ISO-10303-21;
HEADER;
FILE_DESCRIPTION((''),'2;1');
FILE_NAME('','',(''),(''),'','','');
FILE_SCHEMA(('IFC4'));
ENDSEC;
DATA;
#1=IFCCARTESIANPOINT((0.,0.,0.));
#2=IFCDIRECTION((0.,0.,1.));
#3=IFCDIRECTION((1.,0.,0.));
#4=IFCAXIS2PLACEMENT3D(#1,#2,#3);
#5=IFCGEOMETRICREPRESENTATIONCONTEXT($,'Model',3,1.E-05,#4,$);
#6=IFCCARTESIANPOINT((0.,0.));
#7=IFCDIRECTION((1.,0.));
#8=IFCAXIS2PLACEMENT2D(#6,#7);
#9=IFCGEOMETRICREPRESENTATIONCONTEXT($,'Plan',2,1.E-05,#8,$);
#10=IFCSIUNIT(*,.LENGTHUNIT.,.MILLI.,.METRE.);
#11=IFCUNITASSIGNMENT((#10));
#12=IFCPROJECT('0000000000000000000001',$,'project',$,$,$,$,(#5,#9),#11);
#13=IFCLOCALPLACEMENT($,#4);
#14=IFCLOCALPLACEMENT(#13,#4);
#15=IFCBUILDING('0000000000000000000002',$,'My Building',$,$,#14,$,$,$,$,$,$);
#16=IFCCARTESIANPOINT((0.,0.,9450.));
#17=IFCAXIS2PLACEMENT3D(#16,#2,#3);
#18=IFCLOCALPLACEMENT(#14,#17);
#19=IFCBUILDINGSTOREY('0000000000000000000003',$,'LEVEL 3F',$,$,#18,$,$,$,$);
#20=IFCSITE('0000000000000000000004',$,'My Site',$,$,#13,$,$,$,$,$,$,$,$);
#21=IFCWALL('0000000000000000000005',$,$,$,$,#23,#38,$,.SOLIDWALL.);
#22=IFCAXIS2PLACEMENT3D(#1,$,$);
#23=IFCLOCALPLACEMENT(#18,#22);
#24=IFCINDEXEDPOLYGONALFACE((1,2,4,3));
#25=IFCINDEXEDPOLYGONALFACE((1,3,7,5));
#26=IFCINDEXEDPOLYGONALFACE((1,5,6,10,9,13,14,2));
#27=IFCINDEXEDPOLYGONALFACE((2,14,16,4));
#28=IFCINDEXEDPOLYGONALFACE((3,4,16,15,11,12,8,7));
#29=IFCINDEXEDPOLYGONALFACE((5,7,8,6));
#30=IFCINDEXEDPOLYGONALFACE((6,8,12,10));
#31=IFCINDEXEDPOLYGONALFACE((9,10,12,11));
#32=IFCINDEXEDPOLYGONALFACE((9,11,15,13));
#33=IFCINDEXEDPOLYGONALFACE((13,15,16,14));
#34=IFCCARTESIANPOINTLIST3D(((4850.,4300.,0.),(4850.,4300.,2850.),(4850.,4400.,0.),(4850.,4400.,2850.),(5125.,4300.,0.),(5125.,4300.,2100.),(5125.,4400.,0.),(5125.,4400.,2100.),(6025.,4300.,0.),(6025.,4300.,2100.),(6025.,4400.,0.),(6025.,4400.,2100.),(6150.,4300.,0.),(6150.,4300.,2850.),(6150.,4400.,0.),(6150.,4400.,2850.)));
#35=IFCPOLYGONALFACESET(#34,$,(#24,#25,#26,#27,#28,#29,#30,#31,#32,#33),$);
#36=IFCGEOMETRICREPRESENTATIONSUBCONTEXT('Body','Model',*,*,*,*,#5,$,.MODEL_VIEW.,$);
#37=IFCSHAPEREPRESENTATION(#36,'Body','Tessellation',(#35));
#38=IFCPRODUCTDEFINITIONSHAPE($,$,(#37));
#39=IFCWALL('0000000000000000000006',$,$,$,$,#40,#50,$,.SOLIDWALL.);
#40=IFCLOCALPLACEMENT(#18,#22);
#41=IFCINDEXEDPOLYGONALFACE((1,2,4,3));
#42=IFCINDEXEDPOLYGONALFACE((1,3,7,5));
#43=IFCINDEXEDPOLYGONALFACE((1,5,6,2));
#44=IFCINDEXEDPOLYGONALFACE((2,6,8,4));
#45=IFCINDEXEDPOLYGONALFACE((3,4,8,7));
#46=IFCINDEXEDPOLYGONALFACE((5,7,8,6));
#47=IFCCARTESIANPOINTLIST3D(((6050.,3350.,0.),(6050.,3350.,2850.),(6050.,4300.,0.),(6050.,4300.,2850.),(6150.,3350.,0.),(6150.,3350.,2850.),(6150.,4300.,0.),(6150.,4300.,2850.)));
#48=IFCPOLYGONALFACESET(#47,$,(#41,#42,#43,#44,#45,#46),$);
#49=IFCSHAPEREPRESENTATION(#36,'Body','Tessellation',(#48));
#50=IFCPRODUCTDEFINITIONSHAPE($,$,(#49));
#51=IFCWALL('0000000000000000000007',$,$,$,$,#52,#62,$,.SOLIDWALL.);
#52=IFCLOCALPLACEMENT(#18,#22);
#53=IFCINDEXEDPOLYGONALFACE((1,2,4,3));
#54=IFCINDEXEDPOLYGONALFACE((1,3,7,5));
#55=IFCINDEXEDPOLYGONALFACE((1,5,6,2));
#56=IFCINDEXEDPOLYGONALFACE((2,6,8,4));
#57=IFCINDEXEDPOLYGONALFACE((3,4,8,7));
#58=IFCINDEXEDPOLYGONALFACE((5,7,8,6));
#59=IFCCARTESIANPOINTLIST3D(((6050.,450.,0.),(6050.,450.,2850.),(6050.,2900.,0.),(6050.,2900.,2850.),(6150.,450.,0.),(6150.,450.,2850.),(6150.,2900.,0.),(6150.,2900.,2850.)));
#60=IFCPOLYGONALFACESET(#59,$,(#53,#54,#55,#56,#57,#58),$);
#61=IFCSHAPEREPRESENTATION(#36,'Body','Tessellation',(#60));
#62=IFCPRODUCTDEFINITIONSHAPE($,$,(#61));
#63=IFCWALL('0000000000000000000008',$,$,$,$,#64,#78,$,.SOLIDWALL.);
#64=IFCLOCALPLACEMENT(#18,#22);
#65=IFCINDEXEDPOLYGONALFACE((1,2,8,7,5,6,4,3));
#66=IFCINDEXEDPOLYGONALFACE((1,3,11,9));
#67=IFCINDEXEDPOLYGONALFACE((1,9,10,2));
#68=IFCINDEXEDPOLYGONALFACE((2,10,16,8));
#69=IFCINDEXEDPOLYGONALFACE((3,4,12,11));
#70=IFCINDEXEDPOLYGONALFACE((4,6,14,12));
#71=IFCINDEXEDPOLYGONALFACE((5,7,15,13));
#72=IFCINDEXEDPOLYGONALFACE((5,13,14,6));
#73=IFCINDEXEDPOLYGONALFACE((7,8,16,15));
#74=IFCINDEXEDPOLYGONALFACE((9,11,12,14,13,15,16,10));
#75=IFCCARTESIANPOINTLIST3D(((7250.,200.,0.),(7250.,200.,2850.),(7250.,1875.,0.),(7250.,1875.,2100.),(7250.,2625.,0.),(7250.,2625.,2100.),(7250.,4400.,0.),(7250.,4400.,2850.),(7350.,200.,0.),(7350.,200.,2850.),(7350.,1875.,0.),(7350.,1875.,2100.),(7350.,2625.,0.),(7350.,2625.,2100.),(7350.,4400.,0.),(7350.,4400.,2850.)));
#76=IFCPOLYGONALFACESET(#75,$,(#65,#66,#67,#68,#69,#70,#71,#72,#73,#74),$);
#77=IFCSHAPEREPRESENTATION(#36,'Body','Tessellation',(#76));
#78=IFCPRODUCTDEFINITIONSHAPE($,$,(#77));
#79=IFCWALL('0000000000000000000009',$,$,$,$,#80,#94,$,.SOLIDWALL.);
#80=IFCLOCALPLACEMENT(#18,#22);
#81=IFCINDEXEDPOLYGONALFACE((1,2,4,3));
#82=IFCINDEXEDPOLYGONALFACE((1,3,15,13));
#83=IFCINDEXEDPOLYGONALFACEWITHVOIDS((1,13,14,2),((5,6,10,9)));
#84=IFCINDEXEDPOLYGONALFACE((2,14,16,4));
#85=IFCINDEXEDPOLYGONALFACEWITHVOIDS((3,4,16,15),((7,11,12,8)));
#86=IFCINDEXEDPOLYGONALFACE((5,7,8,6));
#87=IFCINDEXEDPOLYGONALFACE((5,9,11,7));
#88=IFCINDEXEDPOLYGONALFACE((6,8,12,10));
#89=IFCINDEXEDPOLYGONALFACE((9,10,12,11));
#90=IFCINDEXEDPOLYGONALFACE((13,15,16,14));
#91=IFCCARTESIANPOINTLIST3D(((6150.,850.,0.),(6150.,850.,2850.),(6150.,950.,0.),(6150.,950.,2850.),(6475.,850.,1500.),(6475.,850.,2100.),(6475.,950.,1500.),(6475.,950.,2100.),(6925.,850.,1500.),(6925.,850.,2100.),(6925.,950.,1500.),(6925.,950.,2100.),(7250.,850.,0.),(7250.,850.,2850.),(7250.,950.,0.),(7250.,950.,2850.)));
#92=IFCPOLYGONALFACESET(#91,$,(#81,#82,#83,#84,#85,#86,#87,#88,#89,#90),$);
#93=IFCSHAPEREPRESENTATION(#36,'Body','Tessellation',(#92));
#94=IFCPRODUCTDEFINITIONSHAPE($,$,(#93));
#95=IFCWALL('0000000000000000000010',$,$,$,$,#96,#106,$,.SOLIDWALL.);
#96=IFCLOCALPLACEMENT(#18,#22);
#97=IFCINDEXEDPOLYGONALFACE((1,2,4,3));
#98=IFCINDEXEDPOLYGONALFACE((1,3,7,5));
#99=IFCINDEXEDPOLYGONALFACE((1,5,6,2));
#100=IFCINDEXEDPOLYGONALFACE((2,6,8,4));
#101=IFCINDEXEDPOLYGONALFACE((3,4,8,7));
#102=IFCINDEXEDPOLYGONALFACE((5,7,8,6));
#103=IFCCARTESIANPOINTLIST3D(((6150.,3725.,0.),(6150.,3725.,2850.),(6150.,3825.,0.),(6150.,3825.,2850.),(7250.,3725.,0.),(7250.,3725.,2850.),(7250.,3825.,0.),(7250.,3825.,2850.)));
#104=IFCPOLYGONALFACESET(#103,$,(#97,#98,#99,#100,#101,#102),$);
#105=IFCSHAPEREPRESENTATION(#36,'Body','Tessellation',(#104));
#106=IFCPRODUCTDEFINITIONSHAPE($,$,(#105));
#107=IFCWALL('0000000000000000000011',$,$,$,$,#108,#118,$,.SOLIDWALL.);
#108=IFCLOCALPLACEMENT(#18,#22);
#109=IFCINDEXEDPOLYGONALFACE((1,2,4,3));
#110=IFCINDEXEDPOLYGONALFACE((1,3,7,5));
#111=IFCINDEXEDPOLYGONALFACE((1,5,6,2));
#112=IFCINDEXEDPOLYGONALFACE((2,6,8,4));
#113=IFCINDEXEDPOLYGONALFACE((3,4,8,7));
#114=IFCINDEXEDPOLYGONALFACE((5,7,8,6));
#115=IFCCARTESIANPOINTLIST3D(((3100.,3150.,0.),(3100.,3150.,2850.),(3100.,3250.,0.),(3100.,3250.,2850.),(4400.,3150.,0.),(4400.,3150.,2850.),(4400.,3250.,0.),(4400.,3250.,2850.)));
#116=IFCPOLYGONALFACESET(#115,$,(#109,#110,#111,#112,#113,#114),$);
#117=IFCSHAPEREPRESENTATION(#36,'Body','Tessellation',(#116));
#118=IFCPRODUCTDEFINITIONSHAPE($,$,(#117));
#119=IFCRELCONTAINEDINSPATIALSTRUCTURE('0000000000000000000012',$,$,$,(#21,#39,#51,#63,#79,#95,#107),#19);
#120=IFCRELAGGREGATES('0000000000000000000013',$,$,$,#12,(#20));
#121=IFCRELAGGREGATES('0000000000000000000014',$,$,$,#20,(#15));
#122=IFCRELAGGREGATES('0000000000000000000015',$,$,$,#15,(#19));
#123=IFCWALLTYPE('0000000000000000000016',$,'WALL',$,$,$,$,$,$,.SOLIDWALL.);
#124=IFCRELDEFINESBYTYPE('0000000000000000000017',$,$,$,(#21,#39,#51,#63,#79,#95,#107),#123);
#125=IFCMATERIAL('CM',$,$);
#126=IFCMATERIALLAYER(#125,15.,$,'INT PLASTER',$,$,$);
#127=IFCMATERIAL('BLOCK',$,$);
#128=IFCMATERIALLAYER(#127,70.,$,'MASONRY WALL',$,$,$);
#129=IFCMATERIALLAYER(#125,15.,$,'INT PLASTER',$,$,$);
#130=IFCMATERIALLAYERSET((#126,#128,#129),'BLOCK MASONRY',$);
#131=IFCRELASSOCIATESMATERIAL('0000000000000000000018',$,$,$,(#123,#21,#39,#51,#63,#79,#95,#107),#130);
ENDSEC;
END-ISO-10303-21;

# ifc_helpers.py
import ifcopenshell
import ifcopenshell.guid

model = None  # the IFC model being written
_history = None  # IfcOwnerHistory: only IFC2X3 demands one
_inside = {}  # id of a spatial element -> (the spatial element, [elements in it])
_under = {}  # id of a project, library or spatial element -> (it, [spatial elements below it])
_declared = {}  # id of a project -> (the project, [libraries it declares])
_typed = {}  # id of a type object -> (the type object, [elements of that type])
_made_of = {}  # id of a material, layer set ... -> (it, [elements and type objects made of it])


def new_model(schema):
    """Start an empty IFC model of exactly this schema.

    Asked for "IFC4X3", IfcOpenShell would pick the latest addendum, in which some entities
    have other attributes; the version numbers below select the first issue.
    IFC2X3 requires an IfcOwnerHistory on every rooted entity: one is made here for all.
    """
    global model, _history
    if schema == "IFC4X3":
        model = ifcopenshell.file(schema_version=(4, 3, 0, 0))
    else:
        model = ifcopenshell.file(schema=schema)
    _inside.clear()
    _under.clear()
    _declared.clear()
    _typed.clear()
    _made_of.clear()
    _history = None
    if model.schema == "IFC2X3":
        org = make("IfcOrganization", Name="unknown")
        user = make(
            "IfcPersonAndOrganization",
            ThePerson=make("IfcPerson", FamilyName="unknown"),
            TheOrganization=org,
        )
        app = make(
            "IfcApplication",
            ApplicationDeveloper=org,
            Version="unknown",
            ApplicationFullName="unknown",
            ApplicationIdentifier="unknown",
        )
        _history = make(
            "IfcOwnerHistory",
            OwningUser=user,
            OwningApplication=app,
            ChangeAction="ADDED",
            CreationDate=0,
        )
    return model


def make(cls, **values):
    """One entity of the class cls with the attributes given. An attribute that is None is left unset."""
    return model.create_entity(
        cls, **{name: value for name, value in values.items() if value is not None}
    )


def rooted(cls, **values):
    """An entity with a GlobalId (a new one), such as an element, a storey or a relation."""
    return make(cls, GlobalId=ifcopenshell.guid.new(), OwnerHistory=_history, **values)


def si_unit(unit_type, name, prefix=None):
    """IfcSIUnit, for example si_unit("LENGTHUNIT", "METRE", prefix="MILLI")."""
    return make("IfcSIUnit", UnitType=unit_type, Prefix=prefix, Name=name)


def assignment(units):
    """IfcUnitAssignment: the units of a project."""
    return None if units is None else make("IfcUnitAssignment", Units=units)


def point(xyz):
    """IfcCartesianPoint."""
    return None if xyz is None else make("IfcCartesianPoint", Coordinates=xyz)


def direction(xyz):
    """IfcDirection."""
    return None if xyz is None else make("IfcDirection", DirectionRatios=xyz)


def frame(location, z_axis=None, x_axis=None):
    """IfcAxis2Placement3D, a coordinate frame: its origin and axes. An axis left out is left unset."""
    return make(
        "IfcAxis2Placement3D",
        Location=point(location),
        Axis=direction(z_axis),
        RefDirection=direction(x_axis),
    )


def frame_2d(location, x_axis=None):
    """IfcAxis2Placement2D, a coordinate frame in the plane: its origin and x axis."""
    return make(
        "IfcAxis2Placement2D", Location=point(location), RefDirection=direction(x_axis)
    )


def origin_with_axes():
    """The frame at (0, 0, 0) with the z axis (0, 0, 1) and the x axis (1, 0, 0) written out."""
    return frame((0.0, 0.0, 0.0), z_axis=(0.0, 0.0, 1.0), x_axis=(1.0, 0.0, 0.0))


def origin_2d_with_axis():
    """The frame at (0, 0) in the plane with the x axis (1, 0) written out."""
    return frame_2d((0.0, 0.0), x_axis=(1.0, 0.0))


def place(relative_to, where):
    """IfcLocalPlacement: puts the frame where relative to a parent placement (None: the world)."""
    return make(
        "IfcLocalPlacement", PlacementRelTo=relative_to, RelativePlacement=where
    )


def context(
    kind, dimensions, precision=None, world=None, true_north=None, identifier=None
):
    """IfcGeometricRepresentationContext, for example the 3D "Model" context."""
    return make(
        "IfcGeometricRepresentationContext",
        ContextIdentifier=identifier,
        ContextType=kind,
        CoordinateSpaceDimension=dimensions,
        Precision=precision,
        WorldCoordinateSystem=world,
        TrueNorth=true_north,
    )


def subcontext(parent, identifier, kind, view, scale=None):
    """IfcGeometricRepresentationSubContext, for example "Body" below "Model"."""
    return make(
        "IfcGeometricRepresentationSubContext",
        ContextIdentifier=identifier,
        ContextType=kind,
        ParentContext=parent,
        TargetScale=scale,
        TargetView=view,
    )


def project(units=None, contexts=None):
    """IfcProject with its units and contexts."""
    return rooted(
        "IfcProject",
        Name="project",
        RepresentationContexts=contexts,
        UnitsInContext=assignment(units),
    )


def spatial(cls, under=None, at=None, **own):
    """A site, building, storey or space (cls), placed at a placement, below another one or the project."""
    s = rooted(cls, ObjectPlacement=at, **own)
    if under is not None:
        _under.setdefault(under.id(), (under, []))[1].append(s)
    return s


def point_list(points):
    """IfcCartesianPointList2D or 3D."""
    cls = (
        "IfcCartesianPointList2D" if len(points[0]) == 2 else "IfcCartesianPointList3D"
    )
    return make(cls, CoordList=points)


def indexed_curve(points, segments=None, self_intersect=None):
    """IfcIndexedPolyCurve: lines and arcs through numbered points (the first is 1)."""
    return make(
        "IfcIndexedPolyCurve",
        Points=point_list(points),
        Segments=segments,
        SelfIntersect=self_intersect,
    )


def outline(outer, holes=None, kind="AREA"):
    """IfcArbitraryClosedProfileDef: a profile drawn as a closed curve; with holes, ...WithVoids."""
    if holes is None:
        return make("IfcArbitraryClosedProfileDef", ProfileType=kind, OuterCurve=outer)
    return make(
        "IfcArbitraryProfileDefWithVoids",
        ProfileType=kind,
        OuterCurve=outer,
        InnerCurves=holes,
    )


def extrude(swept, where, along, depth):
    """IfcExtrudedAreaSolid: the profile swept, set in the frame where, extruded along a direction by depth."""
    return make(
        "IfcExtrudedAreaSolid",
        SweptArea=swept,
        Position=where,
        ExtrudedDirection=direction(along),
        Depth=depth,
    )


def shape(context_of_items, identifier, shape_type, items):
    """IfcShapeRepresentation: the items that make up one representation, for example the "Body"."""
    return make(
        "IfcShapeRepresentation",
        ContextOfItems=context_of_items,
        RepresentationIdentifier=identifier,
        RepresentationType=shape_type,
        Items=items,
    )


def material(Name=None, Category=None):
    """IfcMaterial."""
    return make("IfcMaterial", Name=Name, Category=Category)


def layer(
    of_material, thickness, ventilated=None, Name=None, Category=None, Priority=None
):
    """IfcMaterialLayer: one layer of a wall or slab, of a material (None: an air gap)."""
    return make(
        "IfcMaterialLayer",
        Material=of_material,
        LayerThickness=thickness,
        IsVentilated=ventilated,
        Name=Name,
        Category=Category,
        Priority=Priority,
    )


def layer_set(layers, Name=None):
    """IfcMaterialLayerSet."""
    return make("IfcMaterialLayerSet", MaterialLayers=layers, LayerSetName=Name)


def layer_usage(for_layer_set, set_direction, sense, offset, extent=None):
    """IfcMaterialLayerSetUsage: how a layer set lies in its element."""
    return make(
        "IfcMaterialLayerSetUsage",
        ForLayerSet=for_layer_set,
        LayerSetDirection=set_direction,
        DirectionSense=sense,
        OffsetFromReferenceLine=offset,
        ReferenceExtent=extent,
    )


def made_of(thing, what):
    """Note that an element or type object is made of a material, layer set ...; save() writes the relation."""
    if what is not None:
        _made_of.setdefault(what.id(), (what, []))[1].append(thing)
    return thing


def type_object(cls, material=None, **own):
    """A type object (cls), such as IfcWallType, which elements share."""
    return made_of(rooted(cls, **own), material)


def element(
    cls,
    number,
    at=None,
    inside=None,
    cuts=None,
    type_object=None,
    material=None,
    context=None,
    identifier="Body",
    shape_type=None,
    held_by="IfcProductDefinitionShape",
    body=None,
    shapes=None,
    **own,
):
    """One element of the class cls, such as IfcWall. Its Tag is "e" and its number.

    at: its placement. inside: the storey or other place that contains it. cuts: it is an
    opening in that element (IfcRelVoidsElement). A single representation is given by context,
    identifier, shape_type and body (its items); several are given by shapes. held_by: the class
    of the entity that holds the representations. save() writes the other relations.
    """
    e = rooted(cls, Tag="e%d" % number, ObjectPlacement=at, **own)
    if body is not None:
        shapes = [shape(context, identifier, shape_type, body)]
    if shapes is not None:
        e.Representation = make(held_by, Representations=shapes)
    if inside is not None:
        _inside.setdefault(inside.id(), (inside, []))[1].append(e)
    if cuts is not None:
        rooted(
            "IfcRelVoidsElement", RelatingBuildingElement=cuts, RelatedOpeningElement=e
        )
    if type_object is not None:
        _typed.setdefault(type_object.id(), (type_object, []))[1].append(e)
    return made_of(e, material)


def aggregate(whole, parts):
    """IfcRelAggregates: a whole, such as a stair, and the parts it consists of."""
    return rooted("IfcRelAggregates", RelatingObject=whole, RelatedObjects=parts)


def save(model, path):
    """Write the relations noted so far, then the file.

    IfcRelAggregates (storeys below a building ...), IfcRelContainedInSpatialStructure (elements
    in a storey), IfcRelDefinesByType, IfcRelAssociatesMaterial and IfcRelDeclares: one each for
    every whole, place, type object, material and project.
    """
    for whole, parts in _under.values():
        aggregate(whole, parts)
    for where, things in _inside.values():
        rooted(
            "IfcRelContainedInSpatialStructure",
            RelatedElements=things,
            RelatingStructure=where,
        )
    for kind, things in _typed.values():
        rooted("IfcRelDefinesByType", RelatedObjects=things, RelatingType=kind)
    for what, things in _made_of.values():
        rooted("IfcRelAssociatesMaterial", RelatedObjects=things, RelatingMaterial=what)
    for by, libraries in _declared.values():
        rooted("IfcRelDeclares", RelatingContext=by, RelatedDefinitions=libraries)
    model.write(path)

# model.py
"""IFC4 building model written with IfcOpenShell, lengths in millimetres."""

from ifc_helpers import new_model, si_unit, frame, origin_with_axes, origin_2d_with_axis, place, context, subcontext, project, spatial, indexed_curve, outline, extrude, material, layer, layer_set, layer_usage, type_object, element, save


model = new_model("IFC4")

# Units and contexts
model_context = context("Model", 3, precision=1e-05, world=origin_with_axes())
plan_context = context("Plan", 2, precision=1e-05, world=origin_2d_with_axis())
body_context = subcontext(model_context, "Body", "Model", "MODEL_VIEW")
ifc_project = project(units=[si_unit("LENGTHUNIT", "METRE", prefix="MILLI")], contexts=[model_context, plan_context])

# Site, building, storey
site_placement = place(None, origin_with_axes())
site = spatial("IfcSite", under=ifc_project, at=site_placement, Name="My Site")
building_placement = place(site_placement, origin_with_axes())
building = spatial("IfcBuilding", under=site, at=building_placement, Name="My Building")
storey_placement = place(building_placement, frame((0.0, 0.0, 9450.0), z_axis=(0.0, 0.0, 1.0), x_axis=(1.0, 0.0, 0.0)))
storey = spatial("IfcBuildingStorey", under=building, at=storey_placement, Name="LEVEL 3F")

# Shared definitions
ifc_material_1 = material(Name="CM")
ifc_layer_1 = layer(ifc_material_1, 15.0, Name="INT PLASTER")
ifc_material_2 = material(Name="BLOCK")
ifc_layer_2 = layer(ifc_material_2, 70.0, Name="MASONRY WALL")
ifc_layer_3 = layer(ifc_material_1, 15.0, Name="INT PLASTER")
ifc_layer_set_1 = layer_set([ifc_layer_1, ifc_layer_2, ifc_layer_3], Name="BLOCK MASONRY")
wall_type = type_object("IfcWallType", Name="WALL", PredefinedType="SOLIDWALL", material=ifc_layer_set_1)

# Wall, opening
ifc_layer_usage_1 = layer_usage(ifc_layer_set_1, "AXIS2", "POSITIVE", 0.0)
wall_1_placement = place(storey_placement, frame((4850.0, 4400.0, 0.0), z_axis=(0.0, 0.0, 1.0), x_axis=(0.0, -1.0, 0.0)))
wall_1 = element("IfcWall", 1, at=wall_1_placement, inside=storey, type_object=wall_type, material=ifc_layer_usage_1, PredefinedType="SOLIDWALL", context=body_context, shape_type="SweptSolid", body=[
    extrude(outline(indexed_curve([(0.0, 0.0), (0.0, 1300.0), (100.0, 1300.0), (100.0, 0.0), (0.0, 0.0)], self_intersect=False)), origin_with_axes(), (0.0, 0.0, 1.0), 2850.0),
])
opening_1_placement = place(wall_1_placement, frame((0.0, 1175.0, 0.0), z_axis=(0.0, 0.0, 1.0), x_axis=(0.0, -1.0, 0.0)))
element("IfcOpeningElement", 2, at=opening_1_placement, cuts=wall_1, PredefinedType="OPENING", context=body_context, shape_type="SweptSolid", body=[
    extrude(outline(indexed_curve([(0.0, 0.0), (0.0, 400.0), (900.0, 400.0), (900.0, 0.0), (0.0, 0.0)], self_intersect=False)), frame((0.0, -100.0, 0.0), z_axis=(0.0, 0.0, 1.0), x_axis=(1.0, 0.0, 0.0)), (0.0, 0.0, 1.0), 2100.0),
])

# Walls
ifc_layer_usage_2 = layer_usage(ifc_layer_set_1, "AXIS2", "POSITIVE", 0.0)
wall_2_placement = place(storey_placement, frame((6150.0, 3350.0, 0.0), z_axis=(0.0, 0.0, 1.0), x_axis=(0.0, 1.0, 0.0)))
element("IfcWall", 3, at=wall_2_placement, inside=storey, type_object=wall_type, material=ifc_layer_usage_2, PredefinedType="SOLIDWALL", context=body_context, shape_type="SweptSolid", body=[
    extrude(outline(indexed_curve([(0.0, 0.0), (0.0, 100.0), (950.0, 100.0), (950.0, 0.0), (0.0, 0.0)], self_intersect=False)), origin_with_axes(), (0.0, 0.0, 1.0), 2850.0),
])
ifc_layer_usage_3 = layer_usage(ifc_layer_set_1, "AXIS2", "POSITIVE", 0.0)
wall_3_placement = place(storey_placement, frame((6150.0, 450.0, 0.0), z_axis=(0.0, 0.0, 1.0), x_axis=(0.0, 1.0, 0.0)))
element("IfcWall", 4, at=wall_3_placement, inside=storey, type_object=wall_type, material=ifc_layer_usage_3, PredefinedType="SOLIDWALL", context=body_context, shape_type="SweptSolid", body=[
    extrude(outline(indexed_curve([(0.0, 0.0), (0.0, 100.0), (2450.0, 100.0), (2450.0, 0.0), (0.0, 0.0)], self_intersect=False)), origin_with_axes(), (0.0, 0.0, 1.0), 2850.0),
])

# Walls, openings
ifc_layer_usage_4 = layer_usage(ifc_layer_set_1, "AXIS2", "POSITIVE", 0.0)
wall_4_placement = place(storey_placement, frame((7350.0, 200.0, 0.0), z_axis=(0.0, 0.0, 1.0), x_axis=(0.0, 1.0, 0.0)))
wall_4 = element("IfcWall", 5, at=wall_4_placement, inside=storey, type_object=wall_type, material=ifc_layer_usage_4, PredefinedType="SOLIDWALL", context=body_context, shape_type="SweptSolid", body=[
    extrude(outline(indexed_curve([(0.0, 0.0), (0.0, 100.0), (4200.0, 100.0), (4200.0, 0.0), (0.0, 0.0)], self_intersect=False)), origin_with_axes(), (0.0, 0.0, 1.0), 2850.0),
])
opening_2_placement = place(wall_4_placement, frame((1675.0, 0.0, 0.0), z_axis=(0.0, 0.0, 1.0), x_axis=(1.0, 0.0, 0.0)))
element("IfcOpeningElement", 6, at=opening_2_placement, cuts=wall_4, PredefinedType="OPENING", context=body_context, shape_type="SweptSolid", body=[
    extrude(outline(indexed_curve([(0.0, 0.0), (0.0, 400.0), (750.0, 400.0), (750.0, 0.0), (0.0, 0.0)], self_intersect=False)), frame((0.0, -100.0, 0.0), z_axis=(0.0, 0.0, 1.0), x_axis=(1.0, 0.0, 0.0)), (0.0, 0.0, 1.0), 2100.0),
])
ifc_layer_usage_5 = layer_usage(ifc_layer_set_1, "AXIS2", "POSITIVE", 0.0)
wall_5_placement = place(storey_placement, frame((6150.0, 950.0, 0.0), z_axis=(0.0, 0.0, 1.0), x_axis=(0.0, -1.0, 0.0)))
wall_5 = element("IfcWall", 7, at=wall_5_placement, inside=storey, type_object=wall_type, material=ifc_layer_usage_5, PredefinedType="SOLIDWALL", context=body_context, shape_type="SweptSolid", body=[
    extrude(outline(indexed_curve([(0.0, 0.0), (0.0, 1100.0), (100.0, 1100.0), (100.0, 0.0), (0.0, 0.0)], self_intersect=False)), origin_with_axes(), (0.0, 0.0, 1.0), 2850.0),
])
opening_3_placement = place(wall_5_placement, frame((0.0, 775.0, 1500.0), z_axis=(0.0, 0.0, 1.0), x_axis=(0.0, -1.0, 0.0)))
element("IfcOpeningElement", 8, at=opening_3_placement, cuts=wall_5, PredefinedType="OPENING", context=body_context, shape_type="SweptSolid", body=[
    extrude(outline(indexed_curve([(0.0, 0.0), (0.0, 400.0), (450.0, 400.0), (450.0, 0.0), (0.0, 0.0)], self_intersect=False)), frame((0.0, -100.0, 0.0), z_axis=(0.0, 0.0, 1.0), x_axis=(1.0, 0.0, 0.0)), (0.0, 0.0, 1.0), 600.0),
])

# Walls
ifc_layer_usage_6 = layer_usage(ifc_layer_set_1, "AXIS2", "POSITIVE", 0.0)
wall_6_placement = place(storey_placement, frame((6150.0, 3825.0, 0.0), z_axis=(0.0, 0.0, 1.0), x_axis=(0.0, -1.0, 0.0)))
element("IfcWall", 9, at=wall_6_placement, inside=storey, type_object=wall_type, material=ifc_layer_usage_6, PredefinedType="SOLIDWALL", context=body_context, shape_type="SweptSolid", body=[
    extrude(outline(indexed_curve([(0.0, 0.0), (0.0, 1100.0), (100.0, 1100.0), (100.0, 0.0), (0.0, 0.0)], self_intersect=False)), origin_with_axes(), (0.0, 0.0, 1.0), 2850.0),
])
ifc_layer_usage_7 = layer_usage(ifc_layer_set_1, "AXIS2", "POSITIVE", 0.0)
wall_7_placement = place(storey_placement, frame((3100.0, 3250.0, 0.0), z_axis=(0.0, 0.0, 1.0), x_axis=(0.0, -1.0, 0.0)))
element("IfcWall", 10, at=wall_7_placement, inside=storey, type_object=wall_type, material=ifc_layer_usage_7, PredefinedType="SOLIDWALL", context=body_context, shape_type="SweptSolid", body=[
    extrude(outline(indexed_curve([(0.0, 0.0), (0.0, 1300.0), (100.0, 1300.0), (100.0, 0.0), (0.0, 0.0)], self_intersect=False)), origin_with_axes(), (0.0, 0.0, 1.0), 2850.0),
])

save(model, "model.ifc")
